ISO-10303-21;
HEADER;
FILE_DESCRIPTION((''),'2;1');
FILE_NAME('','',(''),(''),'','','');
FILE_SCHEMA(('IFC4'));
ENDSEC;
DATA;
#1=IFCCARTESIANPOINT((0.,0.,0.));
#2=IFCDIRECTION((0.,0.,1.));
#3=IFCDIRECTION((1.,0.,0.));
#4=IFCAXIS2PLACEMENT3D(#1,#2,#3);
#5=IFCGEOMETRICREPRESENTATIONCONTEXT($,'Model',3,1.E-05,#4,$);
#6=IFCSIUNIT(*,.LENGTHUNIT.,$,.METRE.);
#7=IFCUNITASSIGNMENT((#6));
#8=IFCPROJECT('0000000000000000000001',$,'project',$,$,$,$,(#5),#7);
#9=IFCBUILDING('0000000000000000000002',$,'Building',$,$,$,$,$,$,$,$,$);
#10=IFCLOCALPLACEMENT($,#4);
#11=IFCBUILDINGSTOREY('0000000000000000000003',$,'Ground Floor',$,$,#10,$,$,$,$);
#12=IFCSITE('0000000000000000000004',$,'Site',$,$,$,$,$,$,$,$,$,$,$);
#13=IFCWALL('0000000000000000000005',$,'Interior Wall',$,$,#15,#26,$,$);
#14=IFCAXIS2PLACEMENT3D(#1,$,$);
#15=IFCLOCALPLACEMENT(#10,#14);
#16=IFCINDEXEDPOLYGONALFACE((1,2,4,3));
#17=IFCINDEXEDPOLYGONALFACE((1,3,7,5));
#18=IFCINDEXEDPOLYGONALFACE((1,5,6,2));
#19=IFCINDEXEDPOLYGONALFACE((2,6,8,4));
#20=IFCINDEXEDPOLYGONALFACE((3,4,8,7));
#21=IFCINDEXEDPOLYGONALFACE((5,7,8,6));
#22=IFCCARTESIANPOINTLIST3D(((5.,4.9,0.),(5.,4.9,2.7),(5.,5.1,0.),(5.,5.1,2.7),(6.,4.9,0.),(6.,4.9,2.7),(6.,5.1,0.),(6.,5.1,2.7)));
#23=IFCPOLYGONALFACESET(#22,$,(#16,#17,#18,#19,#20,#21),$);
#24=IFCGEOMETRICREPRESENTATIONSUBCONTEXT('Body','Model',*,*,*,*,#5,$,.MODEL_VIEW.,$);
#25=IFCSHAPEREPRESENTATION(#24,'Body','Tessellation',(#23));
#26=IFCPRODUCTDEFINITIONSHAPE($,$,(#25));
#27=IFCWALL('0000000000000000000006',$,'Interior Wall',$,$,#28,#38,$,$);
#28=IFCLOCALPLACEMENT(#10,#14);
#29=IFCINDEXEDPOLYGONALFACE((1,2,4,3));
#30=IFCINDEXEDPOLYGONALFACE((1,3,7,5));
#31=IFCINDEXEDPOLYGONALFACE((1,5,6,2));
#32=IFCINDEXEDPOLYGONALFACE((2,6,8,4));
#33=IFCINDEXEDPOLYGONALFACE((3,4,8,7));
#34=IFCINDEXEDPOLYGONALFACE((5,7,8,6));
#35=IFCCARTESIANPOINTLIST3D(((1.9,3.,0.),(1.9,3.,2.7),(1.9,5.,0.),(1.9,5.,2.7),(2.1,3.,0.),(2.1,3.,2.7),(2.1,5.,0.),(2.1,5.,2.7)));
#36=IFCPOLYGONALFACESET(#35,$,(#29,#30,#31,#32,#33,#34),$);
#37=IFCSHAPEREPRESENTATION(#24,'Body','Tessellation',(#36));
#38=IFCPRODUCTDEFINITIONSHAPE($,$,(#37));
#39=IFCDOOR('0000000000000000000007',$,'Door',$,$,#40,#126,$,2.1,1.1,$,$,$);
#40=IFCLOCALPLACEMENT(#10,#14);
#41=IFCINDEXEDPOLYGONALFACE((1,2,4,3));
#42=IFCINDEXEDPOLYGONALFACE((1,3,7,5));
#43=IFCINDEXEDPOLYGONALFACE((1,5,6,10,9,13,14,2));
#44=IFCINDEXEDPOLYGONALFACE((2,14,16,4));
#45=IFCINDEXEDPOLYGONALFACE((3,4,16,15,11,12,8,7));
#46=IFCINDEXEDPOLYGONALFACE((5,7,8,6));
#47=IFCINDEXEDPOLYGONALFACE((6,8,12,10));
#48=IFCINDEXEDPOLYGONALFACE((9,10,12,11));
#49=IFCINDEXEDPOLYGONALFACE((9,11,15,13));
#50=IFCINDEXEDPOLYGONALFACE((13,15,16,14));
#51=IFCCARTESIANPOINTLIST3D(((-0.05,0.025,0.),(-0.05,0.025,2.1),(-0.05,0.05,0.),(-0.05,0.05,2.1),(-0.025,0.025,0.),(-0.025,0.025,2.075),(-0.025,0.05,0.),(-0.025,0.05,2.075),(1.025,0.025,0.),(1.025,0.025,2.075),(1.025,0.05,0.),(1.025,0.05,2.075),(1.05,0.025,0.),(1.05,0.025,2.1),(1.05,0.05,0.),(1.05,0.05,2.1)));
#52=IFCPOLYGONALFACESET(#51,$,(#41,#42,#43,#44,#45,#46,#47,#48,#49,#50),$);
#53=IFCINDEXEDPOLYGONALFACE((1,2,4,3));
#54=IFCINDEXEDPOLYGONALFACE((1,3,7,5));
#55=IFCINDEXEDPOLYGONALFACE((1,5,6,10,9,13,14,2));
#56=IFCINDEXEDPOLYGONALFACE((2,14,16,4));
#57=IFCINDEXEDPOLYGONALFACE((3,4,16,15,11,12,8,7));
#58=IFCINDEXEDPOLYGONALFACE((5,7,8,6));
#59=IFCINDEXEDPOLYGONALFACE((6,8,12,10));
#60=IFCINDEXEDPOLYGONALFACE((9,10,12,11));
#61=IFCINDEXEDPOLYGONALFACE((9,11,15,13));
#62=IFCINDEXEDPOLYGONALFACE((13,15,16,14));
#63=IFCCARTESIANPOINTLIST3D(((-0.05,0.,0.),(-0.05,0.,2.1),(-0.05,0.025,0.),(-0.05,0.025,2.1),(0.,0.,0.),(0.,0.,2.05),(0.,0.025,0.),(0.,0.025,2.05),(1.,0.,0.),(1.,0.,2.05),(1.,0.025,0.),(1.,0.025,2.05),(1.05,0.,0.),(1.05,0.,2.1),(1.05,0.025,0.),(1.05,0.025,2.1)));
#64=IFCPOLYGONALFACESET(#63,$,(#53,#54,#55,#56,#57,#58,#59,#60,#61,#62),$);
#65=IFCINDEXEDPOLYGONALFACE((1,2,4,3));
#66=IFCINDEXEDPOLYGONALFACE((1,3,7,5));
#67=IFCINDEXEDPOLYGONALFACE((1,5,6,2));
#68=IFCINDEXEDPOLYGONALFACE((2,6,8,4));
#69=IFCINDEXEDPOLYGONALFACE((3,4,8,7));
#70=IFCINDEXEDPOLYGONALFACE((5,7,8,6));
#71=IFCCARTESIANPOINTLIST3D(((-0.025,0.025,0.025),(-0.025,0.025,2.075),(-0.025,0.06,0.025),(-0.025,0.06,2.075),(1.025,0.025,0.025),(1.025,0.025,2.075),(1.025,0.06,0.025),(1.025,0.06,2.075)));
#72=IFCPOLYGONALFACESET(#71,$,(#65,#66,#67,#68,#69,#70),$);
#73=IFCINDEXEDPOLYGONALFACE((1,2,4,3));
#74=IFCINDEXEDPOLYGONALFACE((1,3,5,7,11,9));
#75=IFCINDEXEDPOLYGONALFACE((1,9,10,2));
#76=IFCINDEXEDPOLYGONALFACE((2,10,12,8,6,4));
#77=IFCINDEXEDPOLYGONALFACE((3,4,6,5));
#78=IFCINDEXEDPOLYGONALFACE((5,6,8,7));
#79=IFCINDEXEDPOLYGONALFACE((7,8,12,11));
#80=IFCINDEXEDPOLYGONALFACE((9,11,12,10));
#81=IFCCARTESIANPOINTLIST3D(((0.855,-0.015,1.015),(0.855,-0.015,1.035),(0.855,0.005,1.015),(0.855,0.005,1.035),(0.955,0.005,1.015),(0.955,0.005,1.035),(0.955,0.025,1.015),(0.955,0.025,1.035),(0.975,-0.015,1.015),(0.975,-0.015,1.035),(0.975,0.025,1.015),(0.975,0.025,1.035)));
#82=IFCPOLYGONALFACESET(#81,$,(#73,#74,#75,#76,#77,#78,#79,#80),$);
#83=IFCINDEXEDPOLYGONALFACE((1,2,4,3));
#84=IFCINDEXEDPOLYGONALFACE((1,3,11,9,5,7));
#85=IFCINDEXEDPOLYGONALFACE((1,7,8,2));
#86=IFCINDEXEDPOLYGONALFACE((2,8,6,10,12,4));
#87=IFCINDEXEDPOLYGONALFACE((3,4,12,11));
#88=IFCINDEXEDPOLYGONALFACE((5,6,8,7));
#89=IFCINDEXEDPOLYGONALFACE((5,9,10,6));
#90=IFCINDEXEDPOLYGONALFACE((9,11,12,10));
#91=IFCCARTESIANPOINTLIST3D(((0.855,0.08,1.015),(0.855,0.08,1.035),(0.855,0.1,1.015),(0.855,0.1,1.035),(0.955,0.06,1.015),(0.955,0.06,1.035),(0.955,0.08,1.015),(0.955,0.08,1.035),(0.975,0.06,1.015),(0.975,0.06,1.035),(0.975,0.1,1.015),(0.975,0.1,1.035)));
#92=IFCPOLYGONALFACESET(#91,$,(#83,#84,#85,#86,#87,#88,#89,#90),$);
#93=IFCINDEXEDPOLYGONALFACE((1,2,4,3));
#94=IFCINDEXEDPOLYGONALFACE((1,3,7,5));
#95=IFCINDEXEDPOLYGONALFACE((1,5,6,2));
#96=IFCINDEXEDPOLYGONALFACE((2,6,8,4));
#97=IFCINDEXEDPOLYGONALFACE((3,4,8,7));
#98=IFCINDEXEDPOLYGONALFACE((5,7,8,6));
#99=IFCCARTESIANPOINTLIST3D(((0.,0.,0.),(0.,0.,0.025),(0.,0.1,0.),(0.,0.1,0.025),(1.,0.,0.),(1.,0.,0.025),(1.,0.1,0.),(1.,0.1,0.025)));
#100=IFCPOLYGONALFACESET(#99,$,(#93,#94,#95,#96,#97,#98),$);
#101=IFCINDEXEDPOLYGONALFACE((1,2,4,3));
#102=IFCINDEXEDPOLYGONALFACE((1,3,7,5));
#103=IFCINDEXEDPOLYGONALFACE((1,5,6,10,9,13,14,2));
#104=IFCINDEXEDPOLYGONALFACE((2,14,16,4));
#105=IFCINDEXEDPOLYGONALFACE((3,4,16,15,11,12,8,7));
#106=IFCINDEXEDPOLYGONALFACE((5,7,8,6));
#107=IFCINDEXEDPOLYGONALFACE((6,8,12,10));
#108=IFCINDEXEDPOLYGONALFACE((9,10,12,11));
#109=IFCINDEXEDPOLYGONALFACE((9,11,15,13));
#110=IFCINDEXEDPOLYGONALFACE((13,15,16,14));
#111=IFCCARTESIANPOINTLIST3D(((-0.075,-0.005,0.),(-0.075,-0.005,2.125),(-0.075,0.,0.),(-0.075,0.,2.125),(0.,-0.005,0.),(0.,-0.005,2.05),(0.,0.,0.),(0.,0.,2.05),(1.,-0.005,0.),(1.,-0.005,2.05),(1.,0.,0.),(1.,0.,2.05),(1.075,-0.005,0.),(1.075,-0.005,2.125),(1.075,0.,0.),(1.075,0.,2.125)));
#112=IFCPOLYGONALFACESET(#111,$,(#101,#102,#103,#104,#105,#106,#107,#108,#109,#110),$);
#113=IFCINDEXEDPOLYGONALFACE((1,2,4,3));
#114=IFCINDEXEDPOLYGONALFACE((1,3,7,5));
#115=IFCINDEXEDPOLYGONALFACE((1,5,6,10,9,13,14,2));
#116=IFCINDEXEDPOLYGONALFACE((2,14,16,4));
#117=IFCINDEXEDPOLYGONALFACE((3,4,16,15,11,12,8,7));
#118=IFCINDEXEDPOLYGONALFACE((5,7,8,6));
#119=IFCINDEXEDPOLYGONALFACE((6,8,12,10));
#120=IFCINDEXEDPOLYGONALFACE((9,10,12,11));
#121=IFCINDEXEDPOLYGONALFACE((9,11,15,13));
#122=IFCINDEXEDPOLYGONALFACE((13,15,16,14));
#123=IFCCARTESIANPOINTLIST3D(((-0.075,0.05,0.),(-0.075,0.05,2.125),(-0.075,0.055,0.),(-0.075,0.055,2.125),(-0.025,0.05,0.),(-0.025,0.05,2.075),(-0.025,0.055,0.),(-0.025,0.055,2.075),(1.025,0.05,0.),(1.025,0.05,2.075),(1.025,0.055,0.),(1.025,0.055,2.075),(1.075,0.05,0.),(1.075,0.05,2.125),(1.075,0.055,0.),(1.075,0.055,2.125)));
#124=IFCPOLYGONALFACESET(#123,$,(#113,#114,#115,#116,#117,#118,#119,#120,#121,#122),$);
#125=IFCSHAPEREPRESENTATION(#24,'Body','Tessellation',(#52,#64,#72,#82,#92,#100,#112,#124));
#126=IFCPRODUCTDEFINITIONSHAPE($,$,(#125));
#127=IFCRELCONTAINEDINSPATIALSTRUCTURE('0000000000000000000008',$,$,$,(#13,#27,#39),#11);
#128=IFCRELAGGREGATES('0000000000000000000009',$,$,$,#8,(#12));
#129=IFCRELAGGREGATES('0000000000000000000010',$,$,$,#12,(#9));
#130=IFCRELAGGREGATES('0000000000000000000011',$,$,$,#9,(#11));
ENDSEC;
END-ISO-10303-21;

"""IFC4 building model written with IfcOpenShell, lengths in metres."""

from ifc_helpers import new_model, si_unit, frame, origin_with_axes, place, context, subcontext, project, spatial, line, indexed_curve, outline, extrude, element, save


model = new_model("IFC4")

# Units and contexts
model_context = context("Model", 3, precision=1e-05, world=origin_with_axes())
body_context = subcontext(model_context, "Body", "Model", "MODEL_VIEW")
ifc_project = project(units=[si_unit("LENGTHUNIT", "METRE")], contexts=[model_context])

# Site, building, storey
site = spatial("IfcSite", under=ifc_project, Name="Site")
building = spatial("IfcBuilding", under=site, Name="Building")
storey_placement = place(None, origin_with_axes())
storey = spatial("IfcBuildingStorey", under=building, at=storey_placement, Name="Ground Floor")

# Walls
wall_1_placement = place(storey_placement, frame((6.0, 5.0, 0.0), z_axis=(0.0, 0.0, 1.0), x_axis=(-1.0, 0.0, 0.0)))
element("IfcWall", 1, at=wall_1_placement, inside=storey, Name="Interior Wall", context=body_context, shape_type="SweptSolid", body=[
    extrude(outline(indexed_curve([(0.0, 0.0), (0.0, 0.2), (1.0, 0.2), (1.0, 0.0), (0.0, 0.0)], self_intersect=False)), frame((0.0, -0.1, 0.0), z_axis=(0.0, 0.0, 1.0), x_axis=(1.0, 0.0, 0.0)), (0.0, 0.0, 1.0), 2.7),
])
wall_2_placement = place(storey_placement, frame((2.0, 5.0, 0.0), z_axis=(0.0, 0.0, 1.0), x_axis=(0.0, -1.0, 0.0)))
element("IfcWall", 2, at=wall_2_placement, inside=storey, Name="Interior Wall", context=body_context, shape_type="SweptSolid", body=[
    extrude(outline(indexed_curve([(0.0, 0.0), (0.0, 0.2), (2.0, 0.2), (2.0, 0.0), (0.0, 0.0)], self_intersect=False)), frame((0.0, -0.1, 0.0), z_axis=(0.0, 0.0, 1.0), x_axis=(1.0, 0.0, 0.0)), (0.0, 0.0, 1.0), 2.7),
])

# Door
door_1_placement = place(storey_placement, frame((-0.05, 0.0, 0.0), z_axis=(0.0, 0.0, 1.0), x_axis=(1.0, 0.0, 0.0)))
element("IfcDoor", 3, at=door_1_placement, inside=storey, Name="Door", OverallHeight=2.1, OverallWidth=1.1, context=body_context, shape_type="SweptSolid", body=[
    extrude(outline(indexed_curve([(0.0, 0.0), (0.0, 2.1), (1.1, 2.1), (1.1, 0.0), (1.075, 0.0), (1.075, 2.075), (0.025, 2.075), (0.025, 0.0)], segments=[line(1, 2, 3, 4, 5, 6, 7, 8, 1)])), frame((0.0, 0.025, 0.0), z_axis=(0.0, -1.0, 0.0), x_axis=(1.0, 0.0, 0.0)), (0.0, 0.0, -1.0), 0.025),
    extrude(outline(indexed_curve([(0.0, 0.0), (0.0, 2.1), (1.1, 2.1), (1.1, 0.0), (1.05, 0.0), (1.05, 2.05), (0.05, 2.05), (0.05, 0.0)], segments=[line(1, 2, 3, 4, 5, 6, 7, 8, 1)])), frame((0.0, 0.0, 0.0), z_axis=(0.0, -1.0, 0.0), x_axis=(1.0, 0.0, 0.0)), (0.0, 0.0, -1.0), 0.025),
    extrude(outline(indexed_curve([(0.0, 0.0), (1.05, 0.0), (1.05, 0.035), (0.0, 0.035)], segments=[line(1, 2, 3, 4, 1)])), frame((0.025, 0.025, 0.025), z_axis=(0.0, 0.0, 1.0), x_axis=(1.0, 0.0, 0.0)), (0.0, 0.0, 1.0), 2.05),
    extrude(outline(indexed_curve([(0.0, 0.0), (0.0, -0.04), (-0.12, -0.04), (-0.12, -0.02), (-0.02, -0.02), (-0.02, 0.0)], segments=[line(1, 2, 3, 4, 5, 6, 1)])), frame((1.025, 0.025, 1.015), z_axis=(0.0, 0.0, 1.0), x_axis=(1.0, 0.0, 0.0)), (0.0, 0.0, 1.0), 0.02),
    extrude(outline(indexed_curve([(0.0, 0.0), (0.0, 0.04), (-0.12, 0.04), (-0.12, 0.02), (-0.02, 0.02), (-0.02, 0.0)], segments=[line(1, 2, 3, 4, 5, 6, 1)])), frame((1.025, 0.06, 1.015), z_axis=(0.0, 0.0, 1.0), x_axis=(1.0, 0.0, 0.0)), (0.0, 0.0, 1.0), 0.02),
    extrude(outline(indexed_curve([(0.0, 0.0), (1.0, 0.0), (1.0, 0.1), (0.0, 0.1)], segments=[line(1, 2, 3, 4, 1)])), frame((0.05, 0.0, 0.0), z_axis=(0.0, 0.0, 1.0), x_axis=(1.0, 0.0, 0.0)), (0.0, 0.0, 1.0), 0.025),
    extrude(outline(indexed_curve([(0.0, 0.0), (0.0, 2.125), (1.15, 2.125), (1.15, 0.0), (1.075, 0.0), (1.075, 2.05), (0.075, 2.05), (0.075, 0.0)], segments=[line(1, 2, 3, 4, 5, 6, 7, 8, 1)])), frame((-0.025, -0.005, 0.0), z_axis=(0.0, -1.0, 0.0), x_axis=(1.0, 0.0, 0.0)), (0.0, 0.0, -1.0), 0.005),
    extrude(outline(indexed_curve([(0.0, 0.0), (0.0, 2.125), (1.15, 2.125), (1.15, 0.0), (1.1, 0.0), (1.1, 2.075), (0.05, 2.075), (0.05, 0.0)], segments=[line(1, 2, 3, 4, 5, 6, 7, 8, 1)])), frame((-0.025, 0.05, 0.0), z_axis=(0.0, -1.0, 0.0), x_axis=(1.0, 0.0, 0.0)), (0.0, 0.0, -1.0), 0.005),
])

save(model, "model.ifc")
